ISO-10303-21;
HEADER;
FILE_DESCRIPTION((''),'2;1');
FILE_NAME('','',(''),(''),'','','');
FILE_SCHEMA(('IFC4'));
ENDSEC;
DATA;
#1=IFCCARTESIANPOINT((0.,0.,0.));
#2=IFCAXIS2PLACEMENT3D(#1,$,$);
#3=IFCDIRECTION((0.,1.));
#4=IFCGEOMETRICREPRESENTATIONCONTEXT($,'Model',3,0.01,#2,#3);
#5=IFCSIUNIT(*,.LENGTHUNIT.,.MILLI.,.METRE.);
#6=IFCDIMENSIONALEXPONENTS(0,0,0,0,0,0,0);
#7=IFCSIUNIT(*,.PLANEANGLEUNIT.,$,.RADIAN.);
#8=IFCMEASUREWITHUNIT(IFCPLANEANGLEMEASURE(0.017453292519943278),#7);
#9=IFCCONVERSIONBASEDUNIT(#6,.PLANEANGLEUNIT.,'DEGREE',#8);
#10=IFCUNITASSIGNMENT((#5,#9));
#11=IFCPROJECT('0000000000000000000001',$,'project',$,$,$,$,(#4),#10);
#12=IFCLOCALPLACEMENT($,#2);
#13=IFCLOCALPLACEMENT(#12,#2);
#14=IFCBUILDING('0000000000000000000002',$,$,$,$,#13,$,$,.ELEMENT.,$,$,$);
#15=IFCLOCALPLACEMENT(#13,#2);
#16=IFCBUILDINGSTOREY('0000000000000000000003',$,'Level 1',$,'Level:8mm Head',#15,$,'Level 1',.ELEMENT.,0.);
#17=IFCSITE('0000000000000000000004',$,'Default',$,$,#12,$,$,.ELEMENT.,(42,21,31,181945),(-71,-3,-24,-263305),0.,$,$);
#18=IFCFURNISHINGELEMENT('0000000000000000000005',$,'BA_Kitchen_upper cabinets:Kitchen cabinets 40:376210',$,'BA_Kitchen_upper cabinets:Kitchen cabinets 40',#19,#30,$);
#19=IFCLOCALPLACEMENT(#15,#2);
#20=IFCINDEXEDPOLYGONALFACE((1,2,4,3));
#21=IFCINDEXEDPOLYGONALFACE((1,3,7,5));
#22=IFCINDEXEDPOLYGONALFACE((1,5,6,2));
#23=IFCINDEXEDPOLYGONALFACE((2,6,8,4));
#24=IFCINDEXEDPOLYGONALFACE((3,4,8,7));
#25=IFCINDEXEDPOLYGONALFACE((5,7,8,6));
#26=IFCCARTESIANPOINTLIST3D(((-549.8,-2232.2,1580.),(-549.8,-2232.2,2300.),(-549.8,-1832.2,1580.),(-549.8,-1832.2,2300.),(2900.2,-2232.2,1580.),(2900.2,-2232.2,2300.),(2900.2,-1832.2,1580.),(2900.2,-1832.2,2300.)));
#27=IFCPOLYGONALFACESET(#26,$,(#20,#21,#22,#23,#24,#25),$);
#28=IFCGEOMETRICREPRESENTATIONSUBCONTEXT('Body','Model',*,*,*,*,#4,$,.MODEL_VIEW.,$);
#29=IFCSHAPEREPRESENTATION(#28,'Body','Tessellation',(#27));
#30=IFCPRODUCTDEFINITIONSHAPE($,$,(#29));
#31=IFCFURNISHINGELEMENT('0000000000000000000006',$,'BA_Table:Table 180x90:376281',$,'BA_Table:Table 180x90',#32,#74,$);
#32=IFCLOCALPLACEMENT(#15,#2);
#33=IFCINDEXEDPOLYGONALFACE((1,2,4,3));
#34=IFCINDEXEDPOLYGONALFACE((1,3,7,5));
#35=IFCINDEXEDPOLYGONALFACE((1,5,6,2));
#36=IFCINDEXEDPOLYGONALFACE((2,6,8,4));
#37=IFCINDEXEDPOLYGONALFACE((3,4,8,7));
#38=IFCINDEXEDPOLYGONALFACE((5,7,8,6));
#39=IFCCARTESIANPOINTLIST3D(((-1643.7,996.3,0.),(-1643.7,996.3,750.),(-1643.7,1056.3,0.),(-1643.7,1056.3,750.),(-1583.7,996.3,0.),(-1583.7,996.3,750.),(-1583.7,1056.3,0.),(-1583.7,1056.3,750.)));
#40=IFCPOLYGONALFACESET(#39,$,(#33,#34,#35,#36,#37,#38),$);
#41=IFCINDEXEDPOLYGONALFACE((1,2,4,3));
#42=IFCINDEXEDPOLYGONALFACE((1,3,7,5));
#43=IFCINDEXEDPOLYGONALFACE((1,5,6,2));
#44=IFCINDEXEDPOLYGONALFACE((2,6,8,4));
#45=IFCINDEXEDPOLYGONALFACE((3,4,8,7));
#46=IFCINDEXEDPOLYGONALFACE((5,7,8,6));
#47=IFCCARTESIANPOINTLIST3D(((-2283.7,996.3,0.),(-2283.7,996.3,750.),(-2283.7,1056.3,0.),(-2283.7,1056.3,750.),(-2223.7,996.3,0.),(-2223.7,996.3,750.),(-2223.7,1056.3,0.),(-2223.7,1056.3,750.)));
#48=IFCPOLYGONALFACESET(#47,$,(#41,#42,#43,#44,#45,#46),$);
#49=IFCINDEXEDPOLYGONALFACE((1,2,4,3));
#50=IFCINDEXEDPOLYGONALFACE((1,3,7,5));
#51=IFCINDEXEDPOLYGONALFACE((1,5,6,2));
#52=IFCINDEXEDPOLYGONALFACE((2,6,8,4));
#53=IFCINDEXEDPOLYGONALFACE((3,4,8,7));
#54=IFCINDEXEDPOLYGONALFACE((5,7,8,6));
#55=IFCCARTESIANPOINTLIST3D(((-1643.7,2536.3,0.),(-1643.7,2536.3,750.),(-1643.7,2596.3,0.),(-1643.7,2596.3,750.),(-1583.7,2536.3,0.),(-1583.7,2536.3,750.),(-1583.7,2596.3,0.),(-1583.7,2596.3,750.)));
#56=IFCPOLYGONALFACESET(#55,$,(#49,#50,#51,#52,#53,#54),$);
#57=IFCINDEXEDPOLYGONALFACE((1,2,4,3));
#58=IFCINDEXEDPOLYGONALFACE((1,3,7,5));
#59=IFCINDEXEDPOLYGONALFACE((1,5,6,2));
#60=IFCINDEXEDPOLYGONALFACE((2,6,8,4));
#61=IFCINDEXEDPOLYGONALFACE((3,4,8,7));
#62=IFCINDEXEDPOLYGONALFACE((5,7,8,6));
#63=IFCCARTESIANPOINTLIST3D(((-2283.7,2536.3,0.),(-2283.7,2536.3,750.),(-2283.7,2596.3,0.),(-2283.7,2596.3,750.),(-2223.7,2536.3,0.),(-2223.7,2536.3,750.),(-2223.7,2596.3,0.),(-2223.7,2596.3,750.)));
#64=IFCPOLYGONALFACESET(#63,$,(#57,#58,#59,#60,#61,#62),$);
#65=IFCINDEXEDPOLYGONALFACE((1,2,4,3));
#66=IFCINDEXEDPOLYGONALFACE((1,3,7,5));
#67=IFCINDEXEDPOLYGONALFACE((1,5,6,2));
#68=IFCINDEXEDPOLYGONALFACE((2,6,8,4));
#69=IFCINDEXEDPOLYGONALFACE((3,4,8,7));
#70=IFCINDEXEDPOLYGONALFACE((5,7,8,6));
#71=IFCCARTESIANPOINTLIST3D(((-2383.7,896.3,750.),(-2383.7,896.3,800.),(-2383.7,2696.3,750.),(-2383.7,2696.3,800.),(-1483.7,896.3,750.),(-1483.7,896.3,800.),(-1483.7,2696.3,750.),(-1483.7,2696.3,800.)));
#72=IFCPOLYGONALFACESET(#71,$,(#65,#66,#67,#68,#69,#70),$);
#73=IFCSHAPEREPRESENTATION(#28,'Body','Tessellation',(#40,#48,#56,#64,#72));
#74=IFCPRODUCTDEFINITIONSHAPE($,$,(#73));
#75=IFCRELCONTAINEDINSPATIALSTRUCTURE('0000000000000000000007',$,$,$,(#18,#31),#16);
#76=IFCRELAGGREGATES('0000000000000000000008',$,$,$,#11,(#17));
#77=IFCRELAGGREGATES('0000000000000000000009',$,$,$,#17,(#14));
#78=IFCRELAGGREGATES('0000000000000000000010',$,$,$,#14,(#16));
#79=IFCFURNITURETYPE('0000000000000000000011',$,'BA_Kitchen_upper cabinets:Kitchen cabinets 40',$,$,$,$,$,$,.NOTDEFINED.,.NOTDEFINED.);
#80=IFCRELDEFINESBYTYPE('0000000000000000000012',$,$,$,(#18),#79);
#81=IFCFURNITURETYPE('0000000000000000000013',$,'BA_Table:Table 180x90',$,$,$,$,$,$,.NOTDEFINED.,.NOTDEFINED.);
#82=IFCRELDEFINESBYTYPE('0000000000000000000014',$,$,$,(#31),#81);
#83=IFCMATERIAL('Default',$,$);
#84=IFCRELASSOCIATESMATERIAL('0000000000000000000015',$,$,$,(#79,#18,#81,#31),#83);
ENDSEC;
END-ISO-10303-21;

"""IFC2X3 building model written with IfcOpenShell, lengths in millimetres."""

from ifc_helpers import new_model, entity, si_unit, converted_unit, direction, frame, frame_2d, origin, origin_2d_with_axis, place, context, subcontext, project, spatial, rectangle, extrude, source, transform, mapped, material, type_object, type_shapes, element, save


model = new_model("IFC2X3")

# Units and contexts
model_context = context("Model", 3, precision=0.01, world=origin(), true_north=direction((0.0, 1.0)))
body_context = subcontext(model_context, "Body", "Model", "MODEL_VIEW")
ifc_project = project(units=[si_unit("LENGTHUNIT", "METRE", prefix="MILLI"), converted_unit("PLANEANGLEUNIT", "DEGREE", entity("IfcPlaneAngleMeasure", 0.017453292519943278), si_unit("PLANEANGLEUNIT", "RADIAN"), dimensions=[0, 0, 0, 0, 0, 0, 0])], contexts=[model_context])

# Site, building, storey
site_placement = place(None, origin())
site = spatial("IfcSite", under=ifc_project, at=site_placement, Name="Default", CompositionType="ELEMENT", RefLatitude=(42, 21, 31, 181945), RefLongitude=(-71, -3, -24, -263305), RefElevation=0.0)
building_placement = place(site_placement, origin())
building = spatial("IfcBuilding", under=site, at=building_placement, CompositionType="ELEMENT")
storey_placement = place(building_placement, origin())
storey = spatial("IfcBuildingStorey", under=building, at=storey_placement, Name="Level 1", ObjectType="Level:8mm Head", LongName="Level 1", CompositionType="ELEMENT", Elevation=0.0)

# Shared definitions
ifc_material_1 = material(Name="Default")

# Furnishing elements
furniture_type_1 = type_object("IfcFurnitureType", Name="BA_Kitchen_upper cabinets:Kitchen cabinets 40", AssemblyPlace="NOTDEFINED", material=ifc_material_1)
shared_shape_1 = source(origin(), body_context, "Body", "SweptSolid", [
    extrude(rectangle(XDim=3450.0, YDim=400.0, at=frame_2d((0.0, 0.0), x_axis=(1.0, 0.0))), frame((1725.0, -200.0, 1580.0), z_axis=(0.0, 0.0, 1.0), x_axis=(-1.0, 0.0, 0.0)), (0.0, 0.0, 1.0), 720.0),
])
type_shapes(furniture_type_1, [shared_shape_1])
furnishing_1_placement = place(storey_placement, frame((2900.2, -2232.2, 0.0), z_axis=(0.0, 0.0, 1.0), x_axis=(-1.0, 0.0, 0.0)))
element("IfcFurnishingElement", 1, at=furnishing_1_placement, inside=storey, type_object=furniture_type_1, material=ifc_material_1, Name="BA_Kitchen_upper cabinets:Kitchen cabinets 40:376210", ObjectType="BA_Kitchen_upper cabinets:Kitchen cabinets 40", context=body_context, shape_type="MappedRepresentation", body=[
    mapped(shared_shape_1, transform((0.0, 0.0, 0.0), scale=1.0)),
])
furniture_type_2 = type_object("IfcFurnitureType", Name="BA_Table:Table 180x90", AssemblyPlace="NOTDEFINED", material=ifc_material_1)
shared_shape_2 = source(origin(), body_context, "Body", "SweptSolid", [
    extrude(rectangle(XDim=60.0, YDim=60.0, at=frame_2d((0.0, 0.0), x_axis=(1.0, 0.0))), frame((320.0, -770.0, 0.0), z_axis=(0.0, 0.0, 1.0), x_axis=(-1.0, 0.0, 0.0)), (0.0, 0.0, 1.0), 750.0),
    extrude(rectangle(XDim=60.0, YDim=60.0, at=frame_2d((0.0, 0.0), x_axis=(1.0, 0.0))), frame((-320.0, -770.0, 0.0), z_axis=(0.0, 0.0, 1.0), x_axis=(-1.0, 0.0, 0.0)), (0.0, 0.0, 1.0), 750.0),
    extrude(rectangle(XDim=60.0, YDim=60.0, at=frame_2d((0.0, 0.0), x_axis=(1.0, 0.0))), frame((320.0, 770.0, 0.0), z_axis=(0.0, 0.0, 1.0), x_axis=(-1.0, 0.0, 0.0)), (0.0, 0.0, 1.0), 750.0),
    extrude(rectangle(XDim=60.0, YDim=60.0, at=frame_2d((0.0, 0.0), x_axis=(1.0, 0.0))), frame((-320.0, 770.0, 0.0), z_axis=(0.0, 0.0, 1.0), x_axis=(-1.0, 0.0, 0.0)), (0.0, 0.0, 1.0), 750.0),
    extrude(rectangle(XDim=900.0, YDim=1800.0, at=origin_2d_with_axis()), frame((0.0, 0.0, 750.0), z_axis=(0.0, 0.0, 1.0), x_axis=(-1.0, 0.0, 0.0)), (0.0, 0.0, 1.0), 50.0),
])
type_shapes(furniture_type_2, [shared_shape_2])
furnishing_2_placement = place(storey_placement, frame((-1933.7, 1796.3, 0.0)))
element("IfcFurnishingElement", 2, at=furnishing_2_placement, inside=storey, type_object=furniture_type_2, material=ifc_material_1, Name="BA_Table:Table 180x90:376281", ObjectType="BA_Table:Table 180x90", context=body_context, shape_type="MappedRepresentation", body=[
    mapped(shared_shape_2, transform((0.0, 0.0, 0.0), scale=1.0)),
])

save(model, "model.ifc")
